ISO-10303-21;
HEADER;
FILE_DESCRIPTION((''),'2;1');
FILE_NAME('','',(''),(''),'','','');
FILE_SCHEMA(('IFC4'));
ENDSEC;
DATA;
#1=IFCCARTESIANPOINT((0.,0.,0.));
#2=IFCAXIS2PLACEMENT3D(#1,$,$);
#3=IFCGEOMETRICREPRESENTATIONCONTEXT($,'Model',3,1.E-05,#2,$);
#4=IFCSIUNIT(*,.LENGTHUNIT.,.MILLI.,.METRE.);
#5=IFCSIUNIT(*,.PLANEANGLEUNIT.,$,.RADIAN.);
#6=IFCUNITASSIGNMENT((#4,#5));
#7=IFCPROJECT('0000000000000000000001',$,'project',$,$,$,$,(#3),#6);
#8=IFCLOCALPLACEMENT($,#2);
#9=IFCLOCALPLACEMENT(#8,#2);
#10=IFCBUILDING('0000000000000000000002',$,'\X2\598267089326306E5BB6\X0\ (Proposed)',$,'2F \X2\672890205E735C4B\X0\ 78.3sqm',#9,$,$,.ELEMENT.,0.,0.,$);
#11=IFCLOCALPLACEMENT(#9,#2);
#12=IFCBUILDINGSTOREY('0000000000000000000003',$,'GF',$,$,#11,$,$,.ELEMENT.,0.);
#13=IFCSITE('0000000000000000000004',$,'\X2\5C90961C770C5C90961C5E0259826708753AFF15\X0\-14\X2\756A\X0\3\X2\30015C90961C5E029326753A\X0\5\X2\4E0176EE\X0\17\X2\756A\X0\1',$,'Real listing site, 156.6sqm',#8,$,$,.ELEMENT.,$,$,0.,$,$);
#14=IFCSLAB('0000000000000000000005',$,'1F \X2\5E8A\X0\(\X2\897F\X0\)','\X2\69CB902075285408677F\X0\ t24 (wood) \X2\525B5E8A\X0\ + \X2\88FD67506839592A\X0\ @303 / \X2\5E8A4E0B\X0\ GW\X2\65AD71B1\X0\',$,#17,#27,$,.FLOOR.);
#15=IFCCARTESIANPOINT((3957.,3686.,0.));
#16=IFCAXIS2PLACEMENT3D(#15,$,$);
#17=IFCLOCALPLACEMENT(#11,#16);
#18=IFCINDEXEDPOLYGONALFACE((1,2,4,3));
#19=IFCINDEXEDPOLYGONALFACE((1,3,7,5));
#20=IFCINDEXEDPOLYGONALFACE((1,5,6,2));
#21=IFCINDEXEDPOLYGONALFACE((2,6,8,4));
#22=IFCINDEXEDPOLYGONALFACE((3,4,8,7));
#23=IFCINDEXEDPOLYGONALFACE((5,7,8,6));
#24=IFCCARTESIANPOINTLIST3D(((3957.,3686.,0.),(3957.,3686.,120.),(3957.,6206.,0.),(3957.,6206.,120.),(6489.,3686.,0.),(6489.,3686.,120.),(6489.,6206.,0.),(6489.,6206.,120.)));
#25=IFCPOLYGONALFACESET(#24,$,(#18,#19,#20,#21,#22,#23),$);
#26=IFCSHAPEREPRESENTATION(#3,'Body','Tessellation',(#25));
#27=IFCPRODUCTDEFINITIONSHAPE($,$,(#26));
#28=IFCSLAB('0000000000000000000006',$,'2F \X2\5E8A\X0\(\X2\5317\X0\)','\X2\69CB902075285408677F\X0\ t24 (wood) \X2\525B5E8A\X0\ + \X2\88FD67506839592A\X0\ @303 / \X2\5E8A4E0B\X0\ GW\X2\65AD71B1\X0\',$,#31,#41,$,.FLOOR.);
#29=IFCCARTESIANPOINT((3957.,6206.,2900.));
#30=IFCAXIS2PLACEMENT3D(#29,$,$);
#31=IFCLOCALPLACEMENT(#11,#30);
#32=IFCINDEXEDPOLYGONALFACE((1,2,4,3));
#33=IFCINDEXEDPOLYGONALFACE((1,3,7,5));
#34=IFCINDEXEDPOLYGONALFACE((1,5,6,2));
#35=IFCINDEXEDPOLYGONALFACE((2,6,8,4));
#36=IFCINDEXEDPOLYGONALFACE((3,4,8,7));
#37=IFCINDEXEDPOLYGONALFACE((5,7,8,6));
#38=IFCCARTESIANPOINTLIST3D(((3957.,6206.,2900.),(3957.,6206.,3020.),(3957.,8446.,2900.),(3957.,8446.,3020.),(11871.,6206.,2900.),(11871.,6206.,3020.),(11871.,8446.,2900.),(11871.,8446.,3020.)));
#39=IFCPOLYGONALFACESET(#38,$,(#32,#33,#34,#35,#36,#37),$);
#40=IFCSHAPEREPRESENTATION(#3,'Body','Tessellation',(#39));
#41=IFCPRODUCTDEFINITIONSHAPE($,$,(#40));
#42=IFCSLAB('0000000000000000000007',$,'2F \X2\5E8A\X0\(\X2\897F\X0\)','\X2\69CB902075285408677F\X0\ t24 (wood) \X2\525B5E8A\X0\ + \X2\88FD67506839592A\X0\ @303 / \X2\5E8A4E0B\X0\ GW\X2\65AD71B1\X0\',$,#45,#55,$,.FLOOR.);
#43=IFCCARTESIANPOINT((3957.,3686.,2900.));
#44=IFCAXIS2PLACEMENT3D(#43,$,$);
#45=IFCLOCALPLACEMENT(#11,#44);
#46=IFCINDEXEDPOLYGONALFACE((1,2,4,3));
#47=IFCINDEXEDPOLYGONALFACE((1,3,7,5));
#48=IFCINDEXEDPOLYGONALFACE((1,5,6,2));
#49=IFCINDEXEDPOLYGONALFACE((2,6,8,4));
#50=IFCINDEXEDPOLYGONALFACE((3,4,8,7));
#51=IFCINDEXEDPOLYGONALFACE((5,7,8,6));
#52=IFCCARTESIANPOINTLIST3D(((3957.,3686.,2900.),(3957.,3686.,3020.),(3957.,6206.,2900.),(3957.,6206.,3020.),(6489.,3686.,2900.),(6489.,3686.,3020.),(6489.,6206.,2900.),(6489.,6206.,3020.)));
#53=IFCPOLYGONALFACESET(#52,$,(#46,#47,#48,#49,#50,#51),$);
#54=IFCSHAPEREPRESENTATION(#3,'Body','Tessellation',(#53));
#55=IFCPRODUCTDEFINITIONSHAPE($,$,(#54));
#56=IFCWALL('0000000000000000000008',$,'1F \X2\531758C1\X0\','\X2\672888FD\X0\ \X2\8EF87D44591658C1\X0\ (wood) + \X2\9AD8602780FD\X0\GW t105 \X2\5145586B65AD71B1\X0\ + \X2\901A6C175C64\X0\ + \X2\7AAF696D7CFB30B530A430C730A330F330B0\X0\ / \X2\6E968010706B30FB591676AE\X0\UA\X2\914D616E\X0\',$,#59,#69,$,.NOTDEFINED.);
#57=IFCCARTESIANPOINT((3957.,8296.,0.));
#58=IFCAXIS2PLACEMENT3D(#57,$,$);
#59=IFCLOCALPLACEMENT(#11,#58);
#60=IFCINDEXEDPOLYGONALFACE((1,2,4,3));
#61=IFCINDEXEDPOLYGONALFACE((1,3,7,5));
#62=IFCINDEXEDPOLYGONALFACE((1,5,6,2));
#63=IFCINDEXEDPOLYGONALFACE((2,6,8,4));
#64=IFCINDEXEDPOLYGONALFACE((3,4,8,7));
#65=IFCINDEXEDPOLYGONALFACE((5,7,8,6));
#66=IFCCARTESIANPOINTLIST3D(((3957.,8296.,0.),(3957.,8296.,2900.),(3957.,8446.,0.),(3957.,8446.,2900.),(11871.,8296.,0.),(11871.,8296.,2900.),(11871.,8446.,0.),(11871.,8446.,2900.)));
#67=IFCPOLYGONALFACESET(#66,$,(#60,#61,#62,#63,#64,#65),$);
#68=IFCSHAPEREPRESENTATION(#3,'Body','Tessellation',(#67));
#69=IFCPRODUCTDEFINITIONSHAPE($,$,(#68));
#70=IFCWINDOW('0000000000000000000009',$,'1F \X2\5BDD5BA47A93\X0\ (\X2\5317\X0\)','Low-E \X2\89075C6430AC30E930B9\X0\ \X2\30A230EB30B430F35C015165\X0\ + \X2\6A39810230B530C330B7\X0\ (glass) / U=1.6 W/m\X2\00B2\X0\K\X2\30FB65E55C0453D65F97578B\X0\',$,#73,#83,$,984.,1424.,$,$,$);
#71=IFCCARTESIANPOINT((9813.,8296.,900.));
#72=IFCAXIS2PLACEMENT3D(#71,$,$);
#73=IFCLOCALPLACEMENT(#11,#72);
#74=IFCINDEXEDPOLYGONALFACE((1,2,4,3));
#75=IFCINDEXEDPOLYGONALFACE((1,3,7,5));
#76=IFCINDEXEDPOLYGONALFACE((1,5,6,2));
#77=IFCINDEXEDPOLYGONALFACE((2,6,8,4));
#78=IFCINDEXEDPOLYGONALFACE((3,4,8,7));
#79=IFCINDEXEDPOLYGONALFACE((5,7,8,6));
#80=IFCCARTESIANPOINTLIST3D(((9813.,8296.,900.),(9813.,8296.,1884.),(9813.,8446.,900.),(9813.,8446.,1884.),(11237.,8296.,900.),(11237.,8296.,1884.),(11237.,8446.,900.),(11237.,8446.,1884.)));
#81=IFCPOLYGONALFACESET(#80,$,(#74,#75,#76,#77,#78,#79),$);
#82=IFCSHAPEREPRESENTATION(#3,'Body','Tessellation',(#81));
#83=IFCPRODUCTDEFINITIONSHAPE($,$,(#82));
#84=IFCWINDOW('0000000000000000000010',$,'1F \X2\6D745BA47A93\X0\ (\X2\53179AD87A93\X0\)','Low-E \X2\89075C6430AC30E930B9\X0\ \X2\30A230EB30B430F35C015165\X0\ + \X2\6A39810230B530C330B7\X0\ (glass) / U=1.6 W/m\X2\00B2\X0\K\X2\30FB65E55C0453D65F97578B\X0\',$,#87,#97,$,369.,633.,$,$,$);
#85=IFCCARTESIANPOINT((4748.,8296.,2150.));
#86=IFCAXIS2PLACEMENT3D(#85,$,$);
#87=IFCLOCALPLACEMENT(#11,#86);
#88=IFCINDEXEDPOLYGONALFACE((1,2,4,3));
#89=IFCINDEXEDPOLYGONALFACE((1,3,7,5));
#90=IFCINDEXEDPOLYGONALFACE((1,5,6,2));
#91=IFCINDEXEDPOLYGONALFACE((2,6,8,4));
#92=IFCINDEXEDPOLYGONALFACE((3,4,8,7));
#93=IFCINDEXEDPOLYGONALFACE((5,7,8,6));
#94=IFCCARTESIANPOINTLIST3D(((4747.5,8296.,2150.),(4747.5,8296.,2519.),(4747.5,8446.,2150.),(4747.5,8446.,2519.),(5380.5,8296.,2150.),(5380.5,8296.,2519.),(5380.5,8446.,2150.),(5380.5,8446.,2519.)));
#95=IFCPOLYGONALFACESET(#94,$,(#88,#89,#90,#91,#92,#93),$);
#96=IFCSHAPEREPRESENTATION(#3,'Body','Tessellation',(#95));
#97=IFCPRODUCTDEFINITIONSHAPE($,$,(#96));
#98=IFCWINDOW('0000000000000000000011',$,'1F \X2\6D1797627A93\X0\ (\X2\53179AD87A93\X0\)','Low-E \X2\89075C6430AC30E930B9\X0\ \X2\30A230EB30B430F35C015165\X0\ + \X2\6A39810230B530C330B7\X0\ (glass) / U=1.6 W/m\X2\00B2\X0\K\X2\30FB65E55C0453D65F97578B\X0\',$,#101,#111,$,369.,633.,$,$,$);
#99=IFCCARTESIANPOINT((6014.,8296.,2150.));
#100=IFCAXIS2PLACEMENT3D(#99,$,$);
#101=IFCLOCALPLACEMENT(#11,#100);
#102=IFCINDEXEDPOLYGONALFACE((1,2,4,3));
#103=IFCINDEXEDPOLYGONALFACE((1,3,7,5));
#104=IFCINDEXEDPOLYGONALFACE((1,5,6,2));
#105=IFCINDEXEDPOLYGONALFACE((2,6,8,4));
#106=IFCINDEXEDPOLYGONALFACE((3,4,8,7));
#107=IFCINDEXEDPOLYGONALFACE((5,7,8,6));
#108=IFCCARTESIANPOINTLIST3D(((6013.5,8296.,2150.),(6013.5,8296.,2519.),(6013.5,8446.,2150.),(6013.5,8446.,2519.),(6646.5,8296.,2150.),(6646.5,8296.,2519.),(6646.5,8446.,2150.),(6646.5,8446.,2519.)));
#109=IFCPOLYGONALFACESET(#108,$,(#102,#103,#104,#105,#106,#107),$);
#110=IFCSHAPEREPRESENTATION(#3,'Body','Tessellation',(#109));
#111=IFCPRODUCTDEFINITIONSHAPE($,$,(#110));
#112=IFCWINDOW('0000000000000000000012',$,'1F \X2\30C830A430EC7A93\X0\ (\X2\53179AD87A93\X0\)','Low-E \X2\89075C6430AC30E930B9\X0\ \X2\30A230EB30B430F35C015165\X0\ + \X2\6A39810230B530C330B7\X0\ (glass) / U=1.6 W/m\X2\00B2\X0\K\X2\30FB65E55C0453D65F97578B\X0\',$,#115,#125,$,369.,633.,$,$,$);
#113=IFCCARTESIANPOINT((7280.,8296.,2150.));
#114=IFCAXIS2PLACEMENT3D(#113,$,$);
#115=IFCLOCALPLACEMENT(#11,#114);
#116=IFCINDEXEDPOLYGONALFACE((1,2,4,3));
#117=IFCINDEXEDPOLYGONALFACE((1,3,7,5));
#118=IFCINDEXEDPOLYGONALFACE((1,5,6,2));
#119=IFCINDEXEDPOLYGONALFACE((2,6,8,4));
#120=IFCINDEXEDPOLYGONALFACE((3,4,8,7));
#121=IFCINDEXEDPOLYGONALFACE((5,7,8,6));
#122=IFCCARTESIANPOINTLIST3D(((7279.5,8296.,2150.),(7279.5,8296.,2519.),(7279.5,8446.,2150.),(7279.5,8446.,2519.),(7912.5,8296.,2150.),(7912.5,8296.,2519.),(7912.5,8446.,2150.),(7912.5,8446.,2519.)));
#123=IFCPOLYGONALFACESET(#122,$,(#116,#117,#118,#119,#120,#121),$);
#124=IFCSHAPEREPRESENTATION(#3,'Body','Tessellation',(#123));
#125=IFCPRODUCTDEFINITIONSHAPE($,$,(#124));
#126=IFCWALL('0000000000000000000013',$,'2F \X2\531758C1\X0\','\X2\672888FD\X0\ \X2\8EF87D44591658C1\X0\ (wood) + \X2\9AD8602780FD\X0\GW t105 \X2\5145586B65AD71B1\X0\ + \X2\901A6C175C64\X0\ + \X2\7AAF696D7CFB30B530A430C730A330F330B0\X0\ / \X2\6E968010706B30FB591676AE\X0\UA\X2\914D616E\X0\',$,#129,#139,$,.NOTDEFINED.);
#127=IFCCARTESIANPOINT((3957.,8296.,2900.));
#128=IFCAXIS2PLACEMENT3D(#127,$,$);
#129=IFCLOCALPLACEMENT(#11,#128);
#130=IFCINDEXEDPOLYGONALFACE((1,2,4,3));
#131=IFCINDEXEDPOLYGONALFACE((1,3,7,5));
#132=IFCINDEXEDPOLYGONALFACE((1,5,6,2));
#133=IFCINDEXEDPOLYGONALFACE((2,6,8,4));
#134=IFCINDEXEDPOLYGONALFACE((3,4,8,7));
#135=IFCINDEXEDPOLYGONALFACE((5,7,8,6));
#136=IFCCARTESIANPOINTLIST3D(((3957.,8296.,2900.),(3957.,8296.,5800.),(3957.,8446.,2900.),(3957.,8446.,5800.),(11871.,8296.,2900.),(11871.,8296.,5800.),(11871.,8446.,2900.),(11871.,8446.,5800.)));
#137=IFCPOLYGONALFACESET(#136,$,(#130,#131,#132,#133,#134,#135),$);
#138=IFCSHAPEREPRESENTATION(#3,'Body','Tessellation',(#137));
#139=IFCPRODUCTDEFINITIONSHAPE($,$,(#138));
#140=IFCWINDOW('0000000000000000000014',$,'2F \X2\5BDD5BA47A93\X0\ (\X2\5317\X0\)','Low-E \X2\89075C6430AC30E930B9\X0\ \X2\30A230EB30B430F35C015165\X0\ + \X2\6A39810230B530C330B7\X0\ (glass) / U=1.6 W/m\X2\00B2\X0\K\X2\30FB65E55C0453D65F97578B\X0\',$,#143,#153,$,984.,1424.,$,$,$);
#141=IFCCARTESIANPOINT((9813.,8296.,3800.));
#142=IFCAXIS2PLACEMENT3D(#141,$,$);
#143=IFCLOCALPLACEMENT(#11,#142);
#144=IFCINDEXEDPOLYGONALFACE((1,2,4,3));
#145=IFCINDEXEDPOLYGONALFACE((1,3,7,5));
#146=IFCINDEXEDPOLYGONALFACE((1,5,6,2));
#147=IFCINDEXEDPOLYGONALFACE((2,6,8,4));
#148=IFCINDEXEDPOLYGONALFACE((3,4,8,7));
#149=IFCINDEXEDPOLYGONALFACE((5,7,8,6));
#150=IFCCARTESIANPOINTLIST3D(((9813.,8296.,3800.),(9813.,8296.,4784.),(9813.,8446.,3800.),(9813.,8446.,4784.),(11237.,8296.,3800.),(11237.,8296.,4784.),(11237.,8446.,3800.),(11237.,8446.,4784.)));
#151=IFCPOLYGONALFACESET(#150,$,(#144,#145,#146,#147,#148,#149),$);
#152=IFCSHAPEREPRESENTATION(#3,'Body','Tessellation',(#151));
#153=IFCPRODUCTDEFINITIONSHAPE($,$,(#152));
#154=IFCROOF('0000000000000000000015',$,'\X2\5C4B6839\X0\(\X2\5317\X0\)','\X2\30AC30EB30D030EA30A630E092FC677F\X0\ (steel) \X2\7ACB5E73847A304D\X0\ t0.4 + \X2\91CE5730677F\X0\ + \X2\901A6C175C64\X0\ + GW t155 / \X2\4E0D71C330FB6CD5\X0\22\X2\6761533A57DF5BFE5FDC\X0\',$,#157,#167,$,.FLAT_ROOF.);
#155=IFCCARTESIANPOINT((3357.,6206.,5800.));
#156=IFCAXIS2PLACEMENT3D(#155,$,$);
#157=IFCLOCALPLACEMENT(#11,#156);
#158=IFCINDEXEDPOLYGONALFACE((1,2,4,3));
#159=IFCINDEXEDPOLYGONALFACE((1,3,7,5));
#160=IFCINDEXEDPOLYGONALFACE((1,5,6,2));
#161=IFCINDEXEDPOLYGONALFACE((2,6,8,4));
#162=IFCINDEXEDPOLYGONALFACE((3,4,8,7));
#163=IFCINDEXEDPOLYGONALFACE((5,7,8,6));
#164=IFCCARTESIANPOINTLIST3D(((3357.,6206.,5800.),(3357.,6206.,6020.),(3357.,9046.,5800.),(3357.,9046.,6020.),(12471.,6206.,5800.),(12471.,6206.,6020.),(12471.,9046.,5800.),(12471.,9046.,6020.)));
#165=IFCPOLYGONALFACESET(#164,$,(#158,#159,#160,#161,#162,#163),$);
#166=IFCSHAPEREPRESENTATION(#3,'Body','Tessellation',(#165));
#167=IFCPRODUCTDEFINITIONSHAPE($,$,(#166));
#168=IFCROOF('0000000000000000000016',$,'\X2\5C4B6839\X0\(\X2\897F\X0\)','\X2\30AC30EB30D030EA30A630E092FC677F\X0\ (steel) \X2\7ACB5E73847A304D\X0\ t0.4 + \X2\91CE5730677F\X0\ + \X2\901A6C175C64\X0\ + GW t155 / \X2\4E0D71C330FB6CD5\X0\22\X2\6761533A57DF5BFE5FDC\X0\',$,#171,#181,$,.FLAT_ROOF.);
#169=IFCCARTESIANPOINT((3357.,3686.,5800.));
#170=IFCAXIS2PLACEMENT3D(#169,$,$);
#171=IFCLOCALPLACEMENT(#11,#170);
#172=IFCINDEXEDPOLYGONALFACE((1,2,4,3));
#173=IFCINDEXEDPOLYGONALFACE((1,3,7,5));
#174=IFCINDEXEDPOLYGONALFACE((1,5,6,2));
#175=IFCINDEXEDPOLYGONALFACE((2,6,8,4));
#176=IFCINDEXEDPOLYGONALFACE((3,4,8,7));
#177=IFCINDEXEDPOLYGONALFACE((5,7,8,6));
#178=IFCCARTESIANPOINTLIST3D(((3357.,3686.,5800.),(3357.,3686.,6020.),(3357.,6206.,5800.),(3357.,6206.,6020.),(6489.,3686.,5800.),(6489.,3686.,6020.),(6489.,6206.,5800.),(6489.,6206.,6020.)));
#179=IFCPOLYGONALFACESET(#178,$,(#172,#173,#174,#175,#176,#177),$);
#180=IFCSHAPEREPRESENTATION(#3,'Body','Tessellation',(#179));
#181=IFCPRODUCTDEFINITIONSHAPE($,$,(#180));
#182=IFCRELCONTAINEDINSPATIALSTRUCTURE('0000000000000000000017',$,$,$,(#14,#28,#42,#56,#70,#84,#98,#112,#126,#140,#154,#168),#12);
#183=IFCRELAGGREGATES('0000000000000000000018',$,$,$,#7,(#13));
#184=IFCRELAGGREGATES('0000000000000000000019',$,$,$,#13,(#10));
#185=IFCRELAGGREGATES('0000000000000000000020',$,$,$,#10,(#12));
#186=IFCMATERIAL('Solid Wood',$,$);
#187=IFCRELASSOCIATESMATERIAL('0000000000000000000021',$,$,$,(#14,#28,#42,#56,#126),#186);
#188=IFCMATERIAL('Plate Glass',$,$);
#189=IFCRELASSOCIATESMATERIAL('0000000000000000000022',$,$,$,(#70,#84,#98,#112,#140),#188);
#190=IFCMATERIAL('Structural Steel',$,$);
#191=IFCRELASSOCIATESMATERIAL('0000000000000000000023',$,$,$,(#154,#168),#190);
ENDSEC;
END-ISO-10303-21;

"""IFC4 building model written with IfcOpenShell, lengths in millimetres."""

from ifc_helpers import new_model, si_unit, frame, frame_2d, origin, place, context, project, spatial, rectangle, extrude, material, element, fill, save


model = new_model("IFC4")

# Units and contexts
model_context = context("Model", 3, precision=1e-05, world=origin())
ifc_project = project(units=[si_unit("LENGTHUNIT", "METRE", prefix="MILLI"), si_unit("PLANEANGLEUNIT", "RADIAN")], contexts=[model_context])

# Site, building, storey
site_placement = place(None, origin())
site = spatial("IfcSite", under=ifc_project, at=site_placement, Name="岐阜県岐阜市如月町５-14番3、岐阜市錦町5丁目17番1", ObjectType="Real listing site, 156.6sqm", CompositionType="ELEMENT", RefElevation=0.0)
building_placement = place(site_placement, origin())
building = spatial("IfcBuilding", under=site, at=building_placement, Name="如月錦の家 (Proposed)", ObjectType="2F 木造平屋 78.3sqm", CompositionType="ELEMENT", ElevationOfRefHeight=0.0, ElevationOfTerrain=0.0)
storey_placement = place(building_placement, origin())
storey = spatial("IfcBuildingStorey", under=building, at=storey_placement, Name="GF", CompositionType="ELEMENT", Elevation=0.0)

# Slabs
ifc_material_1 = material(Name="Solid Wood")
slab_1_placement = place(storey_placement, frame((3957.0, 3686.0, 0.0)))
element("IfcSlab", 1, at=slab_1_placement, inside=storey, material=ifc_material_1, Name="1F 床(西)", Description="構造用合板 t24 (wood) 剛床 + 製材根太 @303 / 床下 GW断熱", PredefinedType="FLOOR", context=model_context, shape_type="SweptSolid", body=[
    extrude(rectangle(XDim=2532.0, YDim=2520.0, at=frame_2d((1266.0, 1260.0))), frame((3957.0, 3686.0, 0.0)), (0.0, 0.0, 1.0), 120.0),
])
slab_2_placement = place(storey_placement, frame((3957.0, 6206.0, 2900.0)))
element("IfcSlab", 2, at=slab_2_placement, inside=storey, material=ifc_material_1, Name="2F 床(北)", Description="構造用合板 t24 (wood) 剛床 + 製材根太 @303 / 床下 GW断熱", PredefinedType="FLOOR", context=model_context, shape_type="SweptSolid", body=[
    extrude(rectangle(XDim=7914.0, YDim=2240.0, at=frame_2d((3957.0, 1120.0))), frame((3957.0, 6206.0, 2900.0)), (0.0, 0.0, 1.0), 120.0),
])
slab_3_placement = place(storey_placement, frame((3957.0, 3686.0, 2900.0)))
element("IfcSlab", 3, at=slab_3_placement, inside=storey, material=ifc_material_1, Name="2F 床(西)", Description="構造用合板 t24 (wood) 剛床 + 製材根太 @303 / 床下 GW断熱", PredefinedType="FLOOR", context=model_context, shape_type="SweptSolid", body=[
    extrude(rectangle(XDim=2532.0, YDim=2520.0, at=frame_2d((1266.0, 1260.0))), frame((3957.0, 3686.0, 2900.0)), (0.0, 0.0, 1.0), 120.0),
])

# Wall, openings, windows
wall_1_placement = place(storey_placement, frame((3957.0, 8296.0, 0.0)))
wall_1 = element("IfcWall", 4, at=wall_1_placement, inside=storey, material=ifc_material_1, Name="1F 北壁", Description="木製 軸組外壁 (wood) + 高性能GW t105 充填断熱 + 通気層 + 窯業系サイディング / 準耐火・外皮UA配慮", PredefinedType="NOTDEFINED", context=model_context, shape_type="SweptSolid", body=[
    extrude(rectangle(XDim=7914.0, YDim=150.0, at=frame_2d((3957.0, 75.0))), frame((3957.0, 8296.0, 0.0)), (0.0, 0.0, 1.0), 2900.0),
])
opening_1_placement = place(storey_placement, frame((9813.0, 8296.0, 900.0)))
opening_1 = element("IfcOpeningElement", 5, at=opening_1_placement, cuts=wall_1, PredefinedType="NOTDEFINED", context=model_context, shape_type="SweptSolid", body=[
    extrude(rectangle(XDim=1424.0, YDim=150.0, at=frame_2d((712.0, 75.0))), frame((9813.0, 8296.0, 900.0)), (0.0, 0.0, 1.0), 984.0),
])
opening_2_placement = place(storey_placement, frame((4748.0, 8296.0, 2150.0)))
opening_2 = element("IfcOpeningElement", 6, at=opening_2_placement, cuts=wall_1, PredefinedType="NOTDEFINED", context=model_context, shape_type="SweptSolid", body=[
    extrude(rectangle(XDim=633.0, YDim=150.0, at=frame_2d((316.0, 75.0))), frame((4748.0, 8296.0, 2150.0)), (0.0, 0.0, 1.0), 369.0),
])
opening_3_placement = place(storey_placement, frame((6014.0, 8296.0, 2150.0)))
opening_3 = element("IfcOpeningElement", 7, at=opening_3_placement, cuts=wall_1, PredefinedType="NOTDEFINED", context=model_context, shape_type="SweptSolid", body=[
    extrude(rectangle(XDim=633.0, YDim=150.0, at=frame_2d((316.0, 75.0))), frame((6014.0, 8296.0, 2150.0)), (0.0, 0.0, 1.0), 369.0),
])
opening_4_placement = place(storey_placement, frame((7280.0, 8296.0, 2150.0)))
opening_4 = element("IfcOpeningElement", 8, at=opening_4_placement, cuts=wall_1, PredefinedType="NOTDEFINED", context=model_context, shape_type="SweptSolid", body=[
    extrude(rectangle(XDim=633.0, YDim=150.0, at=frame_2d((316.0, 75.0))), frame((7280.0, 8296.0, 2150.0)), (0.0, 0.0, 1.0), 369.0),
])
ifc_material_2 = material(Name="Plate Glass")
window_1_placement = place(storey_placement, frame((9813.0, 8296.0, 900.0)))
window_1 = element("IfcWindow", 9, at=window_1_placement, inside=storey, material=ifc_material_2, Name="1F 寝室窓 (北)", Description="Low-E 複層ガラス アルゴン封入 + 樹脂サッシ (glass) / U=1.6 W/m²K・日射取得型", OverallHeight=984.0, OverallWidth=1424.0, context=model_context, shape_type="SweptSolid", body=[
    extrude(rectangle(XDim=1424.0, YDim=150.0, at=frame_2d((712.0, 75.0))), frame((9813.0, 8296.0, 900.0)), (0.0, 0.0, 1.0), 984.0),
])
fill(opening_1, window_1)
window_2_placement = place(storey_placement, frame((4748.0, 8296.0, 2150.0)))
window_2 = element("IfcWindow", 10, at=window_2_placement, inside=storey, material=ifc_material_2, Name="1F 浴室窓 (北高窓)", Description="Low-E 複層ガラス アルゴン封入 + 樹脂サッシ (glass) / U=1.6 W/m²K・日射取得型", OverallHeight=369.0, OverallWidth=633.0, context=model_context, shape_type="SweptSolid", body=[
    extrude(rectangle(XDim=633.0, YDim=150.0, at=frame_2d((316.0, 75.0))), frame((4748.0, 8296.0, 2150.0)), (0.0, 0.0, 1.0), 369.0),
])
fill(opening_2, window_2)
window_3_placement = place(storey_placement, frame((6014.0, 8296.0, 2150.0)))
window_3 = element("IfcWindow", 11, at=window_3_placement, inside=storey, material=ifc_material_2, Name="1F 洗面窓 (北高窓)", Description="Low-E 複層ガラス アルゴン封入 + 樹脂サッシ (glass) / U=1.6 W/m²K・日射取得型", OverallHeight=369.0, OverallWidth=633.0, context=model_context, shape_type="SweptSolid", body=[
    extrude(rectangle(XDim=633.0, YDim=150.0, at=frame_2d((316.0, 75.0))), frame((6014.0, 8296.0, 2150.0)), (0.0, 0.0, 1.0), 369.0),
])
fill(opening_3, window_3)
window_4_placement = place(storey_placement, frame((7280.0, 8296.0, 2150.0)))
window_4 = element("IfcWindow", 12, at=window_4_placement, inside=storey, material=ifc_material_2, Name="1F トイレ窓 (北高窓)", Description="Low-E 複層ガラス アルゴン封入 + 樹脂サッシ (glass) / U=1.6 W/m²K・日射取得型", OverallHeight=369.0, OverallWidth=633.0, context=model_context, shape_type="SweptSolid", body=[
    extrude(rectangle(XDim=633.0, YDim=150.0, at=frame_2d((316.0, 75.0))), frame((7280.0, 8296.0, 2150.0)), (0.0, 0.0, 1.0), 369.0),
])
fill(opening_4, window_4)

# Wall, opening, window
wall_2_placement = place(storey_placement, frame((3957.0, 8296.0, 2900.0)))
wall_2 = element("IfcWall", 13, at=wall_2_placement, inside=storey, material=ifc_material_1, Name="2F 北壁", Description="木製 軸組外壁 (wood) + 高性能GW t105 充填断熱 + 通気層 + 窯業系サイディング / 準耐火・外皮UA配慮", PredefinedType="NOTDEFINED", context=model_context, shape_type="SweptSolid", body=[
    extrude(rectangle(XDim=7914.0, YDim=150.0, at=frame_2d((3957.0, 75.0))), frame((3957.0, 8296.0, 2900.0)), (0.0, 0.0, 1.0), 2900.0),
])
opening_5_placement = place(storey_placement, frame((9813.0, 8296.0, 3800.0)))
opening_5 = element("IfcOpeningElement", 14, at=opening_5_placement, cuts=wall_2, PredefinedType="NOTDEFINED", context=model_context, shape_type="SweptSolid", body=[
    extrude(rectangle(XDim=1424.0, YDim=150.0, at=frame_2d((712.0, 75.0))), frame((9813.0, 8296.0, 3800.0)), (0.0, 0.0, 1.0), 984.0),
])
window_5_placement = place(storey_placement, frame((9813.0, 8296.0, 3800.0)))
window_5 = element("IfcWindow", 15, at=window_5_placement, inside=storey, material=ifc_material_2, Name="2F 寝室窓 (北)", Description="Low-E 複層ガラス アルゴン封入 + 樹脂サッシ (glass) / U=1.6 W/m²K・日射取得型", OverallHeight=984.0, OverallWidth=1424.0, context=model_context, shape_type="SweptSolid", body=[
    extrude(rectangle(XDim=1424.0, YDim=150.0, at=frame_2d((712.0, 75.0))), frame((9813.0, 8296.0, 3800.0)), (0.0, 0.0, 1.0), 984.0),
])
fill(opening_5, window_5)

# Roofs
ifc_material_3 = material(Name="Structural Steel")
for number, where, name in (
    (16, (3357.0, 6206.0, 5800.0), "屋根(北)"),
):
    element("IfcRoof", number, at=place(storey_placement, frame(where)), inside=storey, material=ifc_material_3, Name=name, Description="ガルバリウム鋼板 (steel) 立平葺き t0.4 + 野地板 + 通気層 + GW t155 / 不燃・法22条区域対応", PredefinedType="FLAT_ROOF", context=model_context, shape_type="SweptSolid", body=[
        extrude(rectangle(XDim=9114.0, YDim=2840.0, at=frame_2d((4557.0, 1420.0))), frame((3357.0, 6206.0, 5800.0)), (0.0, 0.0, 1.0), 220.0),
    ])
roof_placement = place(storey_placement, frame((3357.0, 3686.0, 5800.0)))
element("IfcRoof", 17, at=roof_placement, inside=storey, material=ifc_material_3, Name="屋根(西)", Description="ガルバリウム鋼板 (steel) 立平葺き t0.4 + 野地板 + 通気層 + GW t155 / 不燃・法22条区域対応", PredefinedType="FLAT_ROOF", context=model_context, shape_type="SweptSolid", body=[
    extrude(rectangle(XDim=3132.0, YDim=2520.0, at=frame_2d((1566.0, 1260.0))), frame((3357.0, 3686.0, 5800.0)), (0.0, 0.0, 1.0), 220.0),
])

save(model, "model.ifc")
